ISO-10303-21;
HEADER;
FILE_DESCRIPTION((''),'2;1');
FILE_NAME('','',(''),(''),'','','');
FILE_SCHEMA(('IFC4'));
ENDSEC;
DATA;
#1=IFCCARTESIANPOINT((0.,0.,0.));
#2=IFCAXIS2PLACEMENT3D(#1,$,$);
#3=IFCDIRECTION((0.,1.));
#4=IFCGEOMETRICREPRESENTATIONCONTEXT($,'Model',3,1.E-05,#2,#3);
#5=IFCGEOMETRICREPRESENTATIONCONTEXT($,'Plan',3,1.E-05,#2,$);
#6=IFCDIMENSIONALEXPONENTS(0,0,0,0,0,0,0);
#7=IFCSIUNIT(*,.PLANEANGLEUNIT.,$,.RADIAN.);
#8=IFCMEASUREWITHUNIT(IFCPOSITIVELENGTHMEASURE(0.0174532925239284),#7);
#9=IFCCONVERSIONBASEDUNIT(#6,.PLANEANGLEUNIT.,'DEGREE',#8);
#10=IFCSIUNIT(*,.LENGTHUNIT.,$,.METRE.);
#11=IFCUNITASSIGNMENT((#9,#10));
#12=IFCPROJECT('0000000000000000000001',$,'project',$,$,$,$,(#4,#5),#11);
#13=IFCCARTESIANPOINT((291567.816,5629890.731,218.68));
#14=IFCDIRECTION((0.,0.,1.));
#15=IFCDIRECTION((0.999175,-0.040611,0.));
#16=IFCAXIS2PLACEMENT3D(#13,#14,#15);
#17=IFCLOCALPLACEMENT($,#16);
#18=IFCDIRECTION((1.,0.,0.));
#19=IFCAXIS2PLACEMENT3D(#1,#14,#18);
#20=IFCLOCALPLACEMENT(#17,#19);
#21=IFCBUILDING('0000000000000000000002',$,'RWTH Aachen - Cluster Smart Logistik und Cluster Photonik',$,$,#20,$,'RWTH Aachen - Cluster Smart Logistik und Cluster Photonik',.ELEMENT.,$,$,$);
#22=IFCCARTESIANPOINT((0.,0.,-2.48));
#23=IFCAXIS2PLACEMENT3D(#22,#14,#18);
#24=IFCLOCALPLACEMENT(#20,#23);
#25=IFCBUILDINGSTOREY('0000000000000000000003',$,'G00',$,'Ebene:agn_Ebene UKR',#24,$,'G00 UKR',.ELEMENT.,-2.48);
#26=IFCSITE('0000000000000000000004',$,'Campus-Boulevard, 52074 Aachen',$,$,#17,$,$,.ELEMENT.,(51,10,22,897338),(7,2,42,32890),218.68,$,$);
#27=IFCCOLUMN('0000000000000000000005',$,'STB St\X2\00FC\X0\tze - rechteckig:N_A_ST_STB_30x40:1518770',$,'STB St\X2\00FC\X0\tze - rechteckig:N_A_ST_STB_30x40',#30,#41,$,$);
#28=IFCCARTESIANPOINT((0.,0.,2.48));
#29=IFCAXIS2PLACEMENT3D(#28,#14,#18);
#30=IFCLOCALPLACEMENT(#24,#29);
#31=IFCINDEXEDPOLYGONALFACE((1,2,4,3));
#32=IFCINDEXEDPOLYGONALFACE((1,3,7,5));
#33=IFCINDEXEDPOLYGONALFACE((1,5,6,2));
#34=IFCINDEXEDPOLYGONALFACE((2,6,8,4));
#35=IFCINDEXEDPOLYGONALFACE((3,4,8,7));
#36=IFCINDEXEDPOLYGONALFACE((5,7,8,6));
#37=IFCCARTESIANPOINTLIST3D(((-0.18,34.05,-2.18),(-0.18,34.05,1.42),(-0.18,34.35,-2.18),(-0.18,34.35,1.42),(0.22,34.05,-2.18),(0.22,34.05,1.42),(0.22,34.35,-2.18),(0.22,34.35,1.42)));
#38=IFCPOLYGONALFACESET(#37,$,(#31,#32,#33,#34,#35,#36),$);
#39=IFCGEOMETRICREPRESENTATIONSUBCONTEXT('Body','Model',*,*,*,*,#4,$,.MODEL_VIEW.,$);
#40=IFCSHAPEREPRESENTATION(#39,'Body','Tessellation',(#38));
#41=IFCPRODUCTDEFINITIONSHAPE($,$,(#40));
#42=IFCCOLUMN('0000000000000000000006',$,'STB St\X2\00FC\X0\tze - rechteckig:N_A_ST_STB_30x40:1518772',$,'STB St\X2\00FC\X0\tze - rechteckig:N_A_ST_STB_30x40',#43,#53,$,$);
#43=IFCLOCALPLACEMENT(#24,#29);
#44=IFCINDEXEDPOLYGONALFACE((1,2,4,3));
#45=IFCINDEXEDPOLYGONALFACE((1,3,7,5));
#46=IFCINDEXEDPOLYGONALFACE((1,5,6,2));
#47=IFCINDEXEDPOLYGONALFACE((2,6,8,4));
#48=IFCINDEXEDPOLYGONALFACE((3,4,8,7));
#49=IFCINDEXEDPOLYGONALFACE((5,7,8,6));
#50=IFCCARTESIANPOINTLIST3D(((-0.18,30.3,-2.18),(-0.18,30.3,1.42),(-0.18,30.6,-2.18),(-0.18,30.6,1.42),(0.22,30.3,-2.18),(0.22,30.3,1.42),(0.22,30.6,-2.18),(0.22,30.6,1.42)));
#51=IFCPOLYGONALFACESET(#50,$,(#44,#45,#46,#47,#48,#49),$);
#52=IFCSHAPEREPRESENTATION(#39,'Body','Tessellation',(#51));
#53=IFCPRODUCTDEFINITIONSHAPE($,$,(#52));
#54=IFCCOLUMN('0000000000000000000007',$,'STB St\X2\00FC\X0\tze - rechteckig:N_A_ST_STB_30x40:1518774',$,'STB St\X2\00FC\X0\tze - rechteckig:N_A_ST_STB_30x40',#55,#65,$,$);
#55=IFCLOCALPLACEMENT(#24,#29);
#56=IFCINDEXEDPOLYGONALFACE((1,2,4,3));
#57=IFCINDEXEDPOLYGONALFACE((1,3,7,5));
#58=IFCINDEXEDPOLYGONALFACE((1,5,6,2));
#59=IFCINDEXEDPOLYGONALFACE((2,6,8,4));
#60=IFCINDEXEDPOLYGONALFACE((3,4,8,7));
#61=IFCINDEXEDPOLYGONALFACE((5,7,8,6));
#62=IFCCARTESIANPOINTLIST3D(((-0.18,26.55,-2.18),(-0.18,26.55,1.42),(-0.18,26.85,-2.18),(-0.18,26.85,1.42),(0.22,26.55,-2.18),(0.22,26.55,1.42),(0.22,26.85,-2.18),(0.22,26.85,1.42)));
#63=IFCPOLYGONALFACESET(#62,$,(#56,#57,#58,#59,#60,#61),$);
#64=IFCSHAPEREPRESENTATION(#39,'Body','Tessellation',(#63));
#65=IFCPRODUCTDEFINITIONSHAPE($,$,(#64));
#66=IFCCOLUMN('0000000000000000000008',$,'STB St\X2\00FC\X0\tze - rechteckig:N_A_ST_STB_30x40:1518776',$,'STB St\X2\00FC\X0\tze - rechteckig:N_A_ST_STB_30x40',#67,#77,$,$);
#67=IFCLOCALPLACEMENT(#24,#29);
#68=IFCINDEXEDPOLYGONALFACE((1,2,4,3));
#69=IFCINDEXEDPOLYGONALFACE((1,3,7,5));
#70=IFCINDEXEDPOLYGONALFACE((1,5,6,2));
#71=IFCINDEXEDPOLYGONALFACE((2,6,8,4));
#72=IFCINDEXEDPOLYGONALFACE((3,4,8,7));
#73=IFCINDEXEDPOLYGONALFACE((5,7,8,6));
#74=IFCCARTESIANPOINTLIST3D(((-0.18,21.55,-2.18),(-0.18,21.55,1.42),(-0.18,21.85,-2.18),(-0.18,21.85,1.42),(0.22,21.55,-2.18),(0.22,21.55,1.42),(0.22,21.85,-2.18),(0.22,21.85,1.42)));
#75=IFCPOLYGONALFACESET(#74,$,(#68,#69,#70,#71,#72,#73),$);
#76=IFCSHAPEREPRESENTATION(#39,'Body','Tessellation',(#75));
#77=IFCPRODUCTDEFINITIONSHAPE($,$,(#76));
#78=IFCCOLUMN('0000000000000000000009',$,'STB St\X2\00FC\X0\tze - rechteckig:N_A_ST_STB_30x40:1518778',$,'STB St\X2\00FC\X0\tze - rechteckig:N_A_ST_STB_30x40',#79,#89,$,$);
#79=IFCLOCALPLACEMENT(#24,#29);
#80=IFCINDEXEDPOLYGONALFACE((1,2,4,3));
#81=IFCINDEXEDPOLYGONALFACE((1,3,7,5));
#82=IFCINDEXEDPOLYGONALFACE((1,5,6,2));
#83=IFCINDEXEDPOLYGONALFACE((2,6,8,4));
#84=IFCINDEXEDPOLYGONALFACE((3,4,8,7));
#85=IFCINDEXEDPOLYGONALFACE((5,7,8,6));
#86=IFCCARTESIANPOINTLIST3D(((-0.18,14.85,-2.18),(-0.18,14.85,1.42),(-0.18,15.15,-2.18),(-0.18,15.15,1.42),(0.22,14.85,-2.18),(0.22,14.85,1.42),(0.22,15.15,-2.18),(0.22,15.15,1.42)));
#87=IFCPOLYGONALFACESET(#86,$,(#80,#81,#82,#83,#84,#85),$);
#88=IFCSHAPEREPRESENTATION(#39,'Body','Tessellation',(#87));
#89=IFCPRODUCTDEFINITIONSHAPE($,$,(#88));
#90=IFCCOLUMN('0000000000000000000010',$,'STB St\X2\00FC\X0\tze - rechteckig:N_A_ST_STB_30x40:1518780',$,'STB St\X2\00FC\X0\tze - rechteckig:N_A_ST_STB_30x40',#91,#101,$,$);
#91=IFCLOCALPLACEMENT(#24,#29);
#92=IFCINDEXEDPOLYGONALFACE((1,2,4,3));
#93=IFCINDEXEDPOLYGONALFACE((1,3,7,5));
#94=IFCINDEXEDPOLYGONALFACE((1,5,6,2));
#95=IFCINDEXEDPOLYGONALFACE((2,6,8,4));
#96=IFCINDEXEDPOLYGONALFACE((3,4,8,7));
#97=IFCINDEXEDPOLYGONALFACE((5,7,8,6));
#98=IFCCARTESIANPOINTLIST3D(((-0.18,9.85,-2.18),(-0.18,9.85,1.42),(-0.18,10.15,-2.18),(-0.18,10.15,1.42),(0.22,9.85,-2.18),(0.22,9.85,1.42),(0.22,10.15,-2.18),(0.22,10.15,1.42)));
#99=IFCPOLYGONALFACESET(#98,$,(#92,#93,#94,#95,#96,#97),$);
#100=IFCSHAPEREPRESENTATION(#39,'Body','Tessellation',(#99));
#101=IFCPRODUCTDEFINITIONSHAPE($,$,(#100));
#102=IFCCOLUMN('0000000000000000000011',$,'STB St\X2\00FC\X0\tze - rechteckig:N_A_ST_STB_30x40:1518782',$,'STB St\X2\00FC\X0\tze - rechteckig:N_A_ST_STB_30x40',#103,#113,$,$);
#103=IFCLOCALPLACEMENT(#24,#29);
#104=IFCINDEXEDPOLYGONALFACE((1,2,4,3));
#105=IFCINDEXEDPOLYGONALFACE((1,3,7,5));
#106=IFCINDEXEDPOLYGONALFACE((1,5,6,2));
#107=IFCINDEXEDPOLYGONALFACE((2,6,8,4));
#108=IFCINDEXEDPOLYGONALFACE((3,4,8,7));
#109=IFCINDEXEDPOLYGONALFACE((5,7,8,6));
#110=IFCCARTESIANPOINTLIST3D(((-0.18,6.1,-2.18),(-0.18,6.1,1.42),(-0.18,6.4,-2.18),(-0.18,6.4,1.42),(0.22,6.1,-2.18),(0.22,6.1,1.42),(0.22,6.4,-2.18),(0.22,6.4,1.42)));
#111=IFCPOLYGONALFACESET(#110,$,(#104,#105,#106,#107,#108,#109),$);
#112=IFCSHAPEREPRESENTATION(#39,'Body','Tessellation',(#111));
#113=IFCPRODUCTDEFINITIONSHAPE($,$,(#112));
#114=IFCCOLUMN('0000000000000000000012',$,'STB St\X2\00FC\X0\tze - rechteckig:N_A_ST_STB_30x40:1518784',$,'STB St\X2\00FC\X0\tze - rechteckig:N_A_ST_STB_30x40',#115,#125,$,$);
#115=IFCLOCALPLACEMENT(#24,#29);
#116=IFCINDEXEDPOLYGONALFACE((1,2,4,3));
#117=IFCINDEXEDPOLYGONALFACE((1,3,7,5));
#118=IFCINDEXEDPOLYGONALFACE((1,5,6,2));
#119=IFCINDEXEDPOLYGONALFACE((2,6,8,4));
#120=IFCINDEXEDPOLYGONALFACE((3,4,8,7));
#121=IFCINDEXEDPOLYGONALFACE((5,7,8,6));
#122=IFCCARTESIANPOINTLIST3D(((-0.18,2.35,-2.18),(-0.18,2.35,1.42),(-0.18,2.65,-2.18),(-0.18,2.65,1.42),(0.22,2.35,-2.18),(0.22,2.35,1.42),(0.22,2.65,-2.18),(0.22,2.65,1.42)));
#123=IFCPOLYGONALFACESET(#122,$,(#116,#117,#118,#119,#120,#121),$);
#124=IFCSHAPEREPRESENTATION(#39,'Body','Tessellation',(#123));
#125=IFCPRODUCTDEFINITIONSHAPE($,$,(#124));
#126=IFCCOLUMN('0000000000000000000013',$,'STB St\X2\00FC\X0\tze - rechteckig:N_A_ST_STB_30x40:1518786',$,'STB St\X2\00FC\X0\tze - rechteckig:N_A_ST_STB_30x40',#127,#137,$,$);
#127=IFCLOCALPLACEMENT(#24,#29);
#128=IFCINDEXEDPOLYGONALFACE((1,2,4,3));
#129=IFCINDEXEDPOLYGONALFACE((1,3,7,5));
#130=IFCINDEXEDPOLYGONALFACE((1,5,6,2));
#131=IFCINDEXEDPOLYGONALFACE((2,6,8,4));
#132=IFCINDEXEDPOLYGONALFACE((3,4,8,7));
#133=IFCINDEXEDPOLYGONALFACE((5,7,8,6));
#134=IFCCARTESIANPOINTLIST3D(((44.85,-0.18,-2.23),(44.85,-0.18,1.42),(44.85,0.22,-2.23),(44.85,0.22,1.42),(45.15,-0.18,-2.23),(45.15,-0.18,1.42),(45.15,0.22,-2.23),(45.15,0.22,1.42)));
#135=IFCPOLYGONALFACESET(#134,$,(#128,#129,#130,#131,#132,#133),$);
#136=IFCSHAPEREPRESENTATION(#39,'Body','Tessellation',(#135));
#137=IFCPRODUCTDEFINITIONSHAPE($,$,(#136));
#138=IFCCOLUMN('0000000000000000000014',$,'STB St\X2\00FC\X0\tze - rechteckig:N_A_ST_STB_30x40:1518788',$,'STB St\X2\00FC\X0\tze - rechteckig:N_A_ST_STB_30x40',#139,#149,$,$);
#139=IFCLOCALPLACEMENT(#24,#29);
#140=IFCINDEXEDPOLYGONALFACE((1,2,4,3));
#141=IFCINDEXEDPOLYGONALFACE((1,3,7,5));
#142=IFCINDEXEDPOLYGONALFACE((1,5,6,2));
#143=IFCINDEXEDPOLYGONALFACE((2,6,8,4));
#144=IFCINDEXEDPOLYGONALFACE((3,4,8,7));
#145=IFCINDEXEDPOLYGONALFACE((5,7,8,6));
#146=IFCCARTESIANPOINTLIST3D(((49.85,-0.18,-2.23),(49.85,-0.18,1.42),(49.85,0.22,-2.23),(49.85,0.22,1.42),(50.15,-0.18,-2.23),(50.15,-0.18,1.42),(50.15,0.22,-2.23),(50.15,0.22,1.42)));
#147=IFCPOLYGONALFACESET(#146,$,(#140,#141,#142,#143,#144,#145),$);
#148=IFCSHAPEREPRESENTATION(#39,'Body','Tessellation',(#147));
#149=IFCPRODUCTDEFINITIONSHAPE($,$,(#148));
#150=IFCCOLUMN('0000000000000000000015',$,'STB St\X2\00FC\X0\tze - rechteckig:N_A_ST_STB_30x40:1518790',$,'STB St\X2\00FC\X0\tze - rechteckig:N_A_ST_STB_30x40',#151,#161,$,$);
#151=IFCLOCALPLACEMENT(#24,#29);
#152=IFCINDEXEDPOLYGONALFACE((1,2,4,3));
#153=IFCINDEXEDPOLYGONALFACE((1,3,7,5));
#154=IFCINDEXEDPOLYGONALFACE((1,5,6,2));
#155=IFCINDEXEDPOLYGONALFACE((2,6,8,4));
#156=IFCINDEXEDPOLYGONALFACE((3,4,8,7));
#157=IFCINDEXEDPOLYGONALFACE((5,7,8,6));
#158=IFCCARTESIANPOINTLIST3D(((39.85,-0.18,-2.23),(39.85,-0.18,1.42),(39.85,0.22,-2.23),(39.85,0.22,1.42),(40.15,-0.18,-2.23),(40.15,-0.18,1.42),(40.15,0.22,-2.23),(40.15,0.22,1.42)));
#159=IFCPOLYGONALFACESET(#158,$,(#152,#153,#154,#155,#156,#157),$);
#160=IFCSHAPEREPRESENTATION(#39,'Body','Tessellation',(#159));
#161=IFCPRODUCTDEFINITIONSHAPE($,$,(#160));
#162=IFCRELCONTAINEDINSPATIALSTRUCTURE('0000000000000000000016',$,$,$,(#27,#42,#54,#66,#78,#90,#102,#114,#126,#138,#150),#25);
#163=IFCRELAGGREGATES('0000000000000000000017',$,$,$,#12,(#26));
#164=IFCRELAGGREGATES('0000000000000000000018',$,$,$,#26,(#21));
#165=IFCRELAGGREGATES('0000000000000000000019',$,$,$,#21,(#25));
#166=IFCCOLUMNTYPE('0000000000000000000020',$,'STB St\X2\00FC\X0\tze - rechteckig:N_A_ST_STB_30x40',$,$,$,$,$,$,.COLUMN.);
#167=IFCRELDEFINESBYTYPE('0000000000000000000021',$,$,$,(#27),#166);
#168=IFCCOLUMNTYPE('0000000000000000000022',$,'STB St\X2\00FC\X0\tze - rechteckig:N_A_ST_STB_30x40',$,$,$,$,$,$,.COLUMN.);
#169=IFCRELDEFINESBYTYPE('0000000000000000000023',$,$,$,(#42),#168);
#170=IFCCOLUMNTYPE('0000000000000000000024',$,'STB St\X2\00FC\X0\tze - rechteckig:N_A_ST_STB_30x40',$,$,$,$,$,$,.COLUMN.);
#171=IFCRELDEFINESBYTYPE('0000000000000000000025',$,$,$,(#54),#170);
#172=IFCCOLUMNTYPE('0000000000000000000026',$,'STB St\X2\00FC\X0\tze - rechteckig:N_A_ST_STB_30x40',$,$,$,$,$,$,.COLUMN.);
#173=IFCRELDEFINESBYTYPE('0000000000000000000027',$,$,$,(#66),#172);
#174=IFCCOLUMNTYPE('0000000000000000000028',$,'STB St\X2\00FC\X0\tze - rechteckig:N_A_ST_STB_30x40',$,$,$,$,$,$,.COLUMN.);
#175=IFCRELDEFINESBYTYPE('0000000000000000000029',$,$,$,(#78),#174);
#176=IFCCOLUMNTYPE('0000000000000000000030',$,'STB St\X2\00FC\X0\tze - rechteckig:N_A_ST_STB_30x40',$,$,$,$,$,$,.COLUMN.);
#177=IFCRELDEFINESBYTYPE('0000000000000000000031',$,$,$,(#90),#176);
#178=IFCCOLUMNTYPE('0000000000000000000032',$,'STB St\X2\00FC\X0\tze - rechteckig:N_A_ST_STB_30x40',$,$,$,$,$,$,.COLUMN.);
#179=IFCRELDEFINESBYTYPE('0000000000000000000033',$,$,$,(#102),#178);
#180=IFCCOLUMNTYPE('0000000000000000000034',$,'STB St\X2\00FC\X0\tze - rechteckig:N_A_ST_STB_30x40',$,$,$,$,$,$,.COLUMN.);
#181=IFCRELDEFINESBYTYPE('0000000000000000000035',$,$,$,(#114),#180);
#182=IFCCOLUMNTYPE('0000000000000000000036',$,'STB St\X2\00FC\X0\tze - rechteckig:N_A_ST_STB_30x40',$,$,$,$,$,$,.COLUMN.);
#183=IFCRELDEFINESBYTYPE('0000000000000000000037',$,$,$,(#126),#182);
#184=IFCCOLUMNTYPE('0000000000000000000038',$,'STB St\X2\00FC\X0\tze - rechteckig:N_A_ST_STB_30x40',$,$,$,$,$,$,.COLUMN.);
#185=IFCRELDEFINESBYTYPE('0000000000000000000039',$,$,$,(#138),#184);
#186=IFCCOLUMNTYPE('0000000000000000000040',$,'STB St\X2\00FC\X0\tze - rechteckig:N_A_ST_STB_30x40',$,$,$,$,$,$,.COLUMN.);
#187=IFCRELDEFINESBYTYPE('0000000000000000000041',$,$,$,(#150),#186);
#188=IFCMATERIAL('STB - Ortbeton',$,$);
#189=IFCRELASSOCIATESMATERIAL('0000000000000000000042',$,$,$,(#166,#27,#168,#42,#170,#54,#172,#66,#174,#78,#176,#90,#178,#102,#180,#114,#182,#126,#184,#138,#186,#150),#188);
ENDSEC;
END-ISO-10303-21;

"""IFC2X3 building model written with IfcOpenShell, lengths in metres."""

from ifc_helpers import new_model, entity, si_unit, converted_unit, direction, frame, frame_2d, origin, origin_with_axes, origin_2d_with_axis, place, context, subcontext, project, spatial, rectangle, extrude, source, transform, mapped, material, type_object, element, save


model = new_model("IFC2X3")

# Units and contexts
model_context = context("Model", 3, precision=1e-05, world=origin(), true_north=direction((0.0, 1.0)))
plan_context = context("Plan", 3, precision=1e-05, world=origin())
body_context = subcontext(model_context, "Body", "Model", "MODEL_VIEW")
ifc_project = project(units=[converted_unit("PLANEANGLEUNIT", "DEGREE", entity("IfcPositiveLengthMeasure", 0.0174532925239284), si_unit("PLANEANGLEUNIT", "RADIAN"), dimensions=[0, 0, 0, 0, 0, 0, 0]), si_unit("LENGTHUNIT", "METRE")], contexts=[model_context, plan_context])

# Site, building, storey
site_placement = place(None, frame((291567.816, 5629890.731, 218.68), z_axis=(0.0, 0.0, 1.0), x_axis=(0.999175, -0.040611, 0.0)))
site = spatial("IfcSite", under=ifc_project, at=site_placement, Name="Campus-Boulevard, 52074 Aachen", CompositionType="ELEMENT", RefLatitude=(51, 10, 22, 897338), RefLongitude=(7, 2, 42, 32890), RefElevation=218.68)
building_placement = place(site_placement, origin_with_axes())
building = spatial("IfcBuilding", under=site, at=building_placement, Name="RWTH Aachen - Cluster Smart Logistik und Cluster Photonik", LongName="RWTH Aachen - Cluster Smart Logistik und Cluster Photonik", CompositionType="ELEMENT")
storey_placement = place(building_placement, frame((0.0, 0.0, -2.48), z_axis=(0.0, 0.0, 1.0), x_axis=(1.0, 0.0, 0.0)))
storey = spatial("IfcBuildingStorey", under=building, at=storey_placement, Name="G00", ObjectType="Ebene:agn_Ebene UKR", LongName="G00 UKR", CompositionType="ELEMENT", Elevation=-2.48)

# Shared definitions
ifc_material = material(Name="STB - Ortbeton")

# Columns
column_type_1 = type_object("IfcColumnType", Name="STB Stütze - rechteckig:N_A_ST_STB_30x40", PredefinedType="COLUMN", material=ifc_material)
shared_shape_1 = source(origin(), body_context, "Body", "SweptSolid", [
    extrude(rectangle(XDim=0.3, YDim=0.4, at=origin_2d_with_axis()), frame((0.02, 34.2, -2.18), z_axis=(0.0, 0.0, 1.0), x_axis=(0.0, -1.0, 0.0)), (0.0, 0.0, 1.0), 3.6),
])
column_1_placement = place(storey_placement, frame((0.0, 0.0, 2.48), z_axis=(0.0, 0.0, 1.0), x_axis=(1.0, 0.0, 0.0)))
element("IfcColumn", 1, at=column_1_placement, inside=storey, type_object=column_type_1, material=ifc_material, Name="STB Stütze - rechteckig:N_A_ST_STB_30x40:1518770", ObjectType="STB Stütze - rechteckig:N_A_ST_STB_30x40", context=body_context, shape_type="MappedRepresentation", body=[
    mapped(shared_shape_1, transform((0.0, 0.0, 0.0), scale=1.0)),
])
column_type_2 = type_object("IfcColumnType", Name="STB Stütze - rechteckig:N_A_ST_STB_30x40", PredefinedType="COLUMN", material=ifc_material)
shared_shape_2 = source(origin(), body_context, "Body", "SweptSolid", [
    extrude(rectangle(XDim=0.3, YDim=0.4, at=origin_2d_with_axis()), frame((0.02, 30.45, -2.18), z_axis=(0.0, 0.0, 1.0), x_axis=(0.0, -1.0, 0.0)), (0.0, 0.0, 1.0), 3.6),
])
column_2_placement = place(storey_placement, frame((0.0, 0.0, 2.48), z_axis=(0.0, 0.0, 1.0), x_axis=(1.0, 0.0, 0.0)))
element("IfcColumn", 2, at=column_2_placement, inside=storey, type_object=column_type_2, material=ifc_material, Name="STB Stütze - rechteckig:N_A_ST_STB_30x40:1518772", ObjectType="STB Stütze - rechteckig:N_A_ST_STB_30x40", context=body_context, shape_type="MappedRepresentation", body=[
    mapped(shared_shape_2, transform((0.0, 0.0, 0.0), scale=1.0)),
])
column_type_3 = type_object("IfcColumnType", Name="STB Stütze - rechteckig:N_A_ST_STB_30x40", PredefinedType="COLUMN", material=ifc_material)
shared_shape_3 = source(origin(), body_context, "Body", "SweptSolid", [
    extrude(rectangle(XDim=0.3, YDim=0.4, at=origin_2d_with_axis()), frame((0.02, 26.7, -2.18), z_axis=(0.0, 0.0, 1.0), x_axis=(0.0, -1.0, 0.0)), (0.0, 0.0, 1.0), 3.6),
])
column_3_placement = place(storey_placement, frame((0.0, 0.0, 2.48), z_axis=(0.0, 0.0, 1.0), x_axis=(1.0, 0.0, 0.0)))
element("IfcColumn", 3, at=column_3_placement, inside=storey, type_object=column_type_3, material=ifc_material, Name="STB Stütze - rechteckig:N_A_ST_STB_30x40:1518774", ObjectType="STB Stütze - rechteckig:N_A_ST_STB_30x40", context=body_context, shape_type="MappedRepresentation", body=[
    mapped(shared_shape_3, transform((0.0, 0.0, 0.0), scale=1.0)),
])
column_type_4 = type_object("IfcColumnType", Name="STB Stütze - rechteckig:N_A_ST_STB_30x40", PredefinedType="COLUMN", material=ifc_material)
shared_shape_4 = source(origin(), body_context, "Body", "SweptSolid", [
    extrude(rectangle(XDim=0.3, YDim=0.4, at=origin_2d_with_axis()), frame((0.02, 21.7, -2.18), z_axis=(0.0, 0.0, 1.0), x_axis=(0.0, -1.0, 0.0)), (0.0, 0.0, 1.0), 3.6),
])
column_4_placement = place(storey_placement, frame((0.0, 0.0, 2.48), z_axis=(0.0, 0.0, 1.0), x_axis=(1.0, 0.0, 0.0)))
element("IfcColumn", 4, at=column_4_placement, inside=storey, type_object=column_type_4, material=ifc_material, Name="STB Stütze - rechteckig:N_A_ST_STB_30x40:1518776", ObjectType="STB Stütze - rechteckig:N_A_ST_STB_30x40", context=body_context, shape_type="MappedRepresentation", body=[
    mapped(shared_shape_4, transform((0.0, 0.0, 0.0), scale=1.0)),
])
column_type_5 = type_object("IfcColumnType", Name="STB Stütze - rechteckig:N_A_ST_STB_30x40", PredefinedType="COLUMN", material=ifc_material)
shared_shape_5 = source(origin(), body_context, "Body", "SweptSolid", [
    extrude(rectangle(XDim=0.3, YDim=0.4, at=origin_2d_with_axis()), frame((0.02, 15.0, -2.18), z_axis=(0.0, 0.0, 1.0), x_axis=(0.0, -1.0, 0.0)), (0.0, 0.0, 1.0), 3.6),
])
column_5_placement = place(storey_placement, frame((0.0, 0.0, 2.48), z_axis=(0.0, 0.0, 1.0), x_axis=(1.0, 0.0, 0.0)))
element("IfcColumn", 5, at=column_5_placement, inside=storey, type_object=column_type_5, material=ifc_material, Name="STB Stütze - rechteckig:N_A_ST_STB_30x40:1518778", ObjectType="STB Stütze - rechteckig:N_A_ST_STB_30x40", context=body_context, shape_type="MappedRepresentation", body=[
    mapped(shared_shape_5, transform((0.0, 0.0, 0.0), scale=1.0)),
])
column_type_6 = type_object("IfcColumnType", Name="STB Stütze - rechteckig:N_A_ST_STB_30x40", PredefinedType="COLUMN", material=ifc_material)
shared_shape_6 = source(origin(), body_context, "Body", "SweptSolid", [
    extrude(rectangle(XDim=0.3, YDim=0.4, at=origin_2d_with_axis()), frame((0.02, 10.0, -2.18), z_axis=(0.0, 0.0, 1.0), x_axis=(0.0, -1.0, 0.0)), (0.0, 0.0, 1.0), 3.6),
])
column_6_placement = place(storey_placement, frame((0.0, 0.0, 2.48), z_axis=(0.0, 0.0, 1.0), x_axis=(1.0, 0.0, 0.0)))
element("IfcColumn", 6, at=column_6_placement, inside=storey, type_object=column_type_6, material=ifc_material, Name="STB Stütze - rechteckig:N_A_ST_STB_30x40:1518780", ObjectType="STB Stütze - rechteckig:N_A_ST_STB_30x40", context=body_context, shape_type="MappedRepresentation", body=[
    mapped(shared_shape_6, transform((0.0, 0.0, 0.0), scale=1.0)),
])
column_type_7 = type_object("IfcColumnType", Name="STB Stütze - rechteckig:N_A_ST_STB_30x40", PredefinedType="COLUMN", material=ifc_material)
shared_shape_7 = source(origin(), body_context, "Body", "SweptSolid", [
    extrude(rectangle(XDim=0.3, YDim=0.4, at=frame_2d((0.0, 0.0), x_axis=(1.0, 0.0))), frame((0.02, 6.25, -2.18), z_axis=(0.0, 0.0, 1.0), x_axis=(0.0, -1.0, 0.0)), (0.0, 0.0, 1.0), 3.6),
])
column_7_placement = place(storey_placement, frame((0.0, 0.0, 2.48), z_axis=(0.0, 0.0, 1.0), x_axis=(1.0, 0.0, 0.0)))
element("IfcColumn", 7, at=column_7_placement, inside=storey, type_object=column_type_7, material=ifc_material, Name="STB Stütze - rechteckig:N_A_ST_STB_30x40:1518782", ObjectType="STB Stütze - rechteckig:N_A_ST_STB_30x40", context=body_context, shape_type="MappedRepresentation", body=[
    mapped(shared_shape_7, transform((0.0, 0.0, 0.0), scale=1.0)),
])
column_type_8 = type_object("IfcColumnType", Name="STB Stütze - rechteckig:N_A_ST_STB_30x40", PredefinedType="COLUMN", material=ifc_material)
shared_shape_8 = source(origin(), body_context, "Body", "SweptSolid", [
    extrude(rectangle(XDim=0.3, YDim=0.4, at=frame_2d((0.0, 0.0), x_axis=(1.0, 0.0))), frame((0.02, 2.5, -2.18), z_axis=(0.0, 0.0, 1.0), x_axis=(0.0, -1.0, 0.0)), (0.0, 0.0, 1.0), 3.6),
])
column_8_placement = place(storey_placement, frame((0.0, 0.0, 2.48), z_axis=(0.0, 0.0, 1.0), x_axis=(1.0, 0.0, 0.0)))
element("IfcColumn", 8, at=column_8_placement, inside=storey, type_object=column_type_8, material=ifc_material, Name="STB Stütze - rechteckig:N_A_ST_STB_30x40:1518784", ObjectType="STB Stütze - rechteckig:N_A_ST_STB_30x40", context=body_context, shape_type="MappedRepresentation", body=[
    mapped(shared_shape_8, transform((0.0, 0.0, 0.0), scale=1.0)),
])
column_type_9 = type_object("IfcColumnType", Name="STB Stütze - rechteckig:N_A_ST_STB_30x40", PredefinedType="COLUMN", material=ifc_material)
shared_shape_9 = source(origin(), body_context, "Body", "SweptSolid", [
    extrude(rectangle(XDim=0.4, YDim=0.3, at=origin_2d_with_axis()), frame((45.0, 0.02, -2.23), z_axis=(0.0, 0.0, 1.0), x_axis=(0.0, -1.0, 0.0)), (0.0, 0.0, 1.0), 3.65),
])
column_9_placement = place(storey_placement, frame((0.0, 0.0, 2.48), z_axis=(0.0, 0.0, 1.0), x_axis=(1.0, 0.0, 0.0)))
element("IfcColumn", 9, at=column_9_placement, inside=storey, type_object=column_type_9, material=ifc_material, Name="STB Stütze - rechteckig:N_A_ST_STB_30x40:1518786", ObjectType="STB Stütze - rechteckig:N_A_ST_STB_30x40", context=body_context, shape_type="MappedRepresentation", body=[
    mapped(shared_shape_9, transform((0.0, 0.0, 0.0), scale=1.0)),
])
column_type_10 = type_object("IfcColumnType", Name="STB Stütze - rechteckig:N_A_ST_STB_30x40", PredefinedType="COLUMN", material=ifc_material)
shared_shape_10 = source(origin(), body_context, "Body", "SweptSolid", [
    extrude(rectangle(XDim=0.4, YDim=0.3, at=origin_2d_with_axis()), frame((50.0, 0.02, -2.23), z_axis=(0.0, 0.0, 1.0), x_axis=(0.0, -1.0, 0.0)), (0.0, 0.0, 1.0), 3.65),
])
column_10_placement = place(storey_placement, frame((0.0, 0.0, 2.48), z_axis=(0.0, 0.0, 1.0), x_axis=(1.0, 0.0, 0.0)))
element("IfcColumn", 10, at=column_10_placement, inside=storey, type_object=column_type_10, material=ifc_material, Name="STB Stütze - rechteckig:N_A_ST_STB_30x40:1518788", ObjectType="STB Stütze - rechteckig:N_A_ST_STB_30x40", context=body_context, shape_type="MappedRepresentation", body=[
    mapped(shared_shape_10, transform((0.0, 0.0, 0.0), scale=1.0)),
])
column_type_11 = type_object("IfcColumnType", Name="STB Stütze - rechteckig:N_A_ST_STB_30x40", PredefinedType="COLUMN", material=ifc_material)
shared_shape_11 = source(origin(), body_context, "Body", "SweptSolid", [
    extrude(rectangle(XDim=0.4, YDim=0.3, at=origin_2d_with_axis()), frame((40.0, 0.02, -2.23), z_axis=(0.0, 0.0, 1.0), x_axis=(0.0, -1.0, 0.0)), (0.0, 0.0, 1.0), 3.65),
])
column_11_placement = place(storey_placement, frame((0.0, 0.0, 2.48), z_axis=(0.0, 0.0, 1.0), x_axis=(1.0, 0.0, 0.0)))
element("IfcColumn", 11, at=column_11_placement, inside=storey, type_object=column_type_11, material=ifc_material, Name="STB Stütze - rechteckig:N_A_ST_STB_30x40:1518790", ObjectType="STB Stütze - rechteckig:N_A_ST_STB_30x40", context=body_context, shape_type="MappedRepresentation", body=[
    mapped(shared_shape_11, transform((0.0, 0.0, 0.0), scale=1.0)),
])

save(model, "model.ifc")
